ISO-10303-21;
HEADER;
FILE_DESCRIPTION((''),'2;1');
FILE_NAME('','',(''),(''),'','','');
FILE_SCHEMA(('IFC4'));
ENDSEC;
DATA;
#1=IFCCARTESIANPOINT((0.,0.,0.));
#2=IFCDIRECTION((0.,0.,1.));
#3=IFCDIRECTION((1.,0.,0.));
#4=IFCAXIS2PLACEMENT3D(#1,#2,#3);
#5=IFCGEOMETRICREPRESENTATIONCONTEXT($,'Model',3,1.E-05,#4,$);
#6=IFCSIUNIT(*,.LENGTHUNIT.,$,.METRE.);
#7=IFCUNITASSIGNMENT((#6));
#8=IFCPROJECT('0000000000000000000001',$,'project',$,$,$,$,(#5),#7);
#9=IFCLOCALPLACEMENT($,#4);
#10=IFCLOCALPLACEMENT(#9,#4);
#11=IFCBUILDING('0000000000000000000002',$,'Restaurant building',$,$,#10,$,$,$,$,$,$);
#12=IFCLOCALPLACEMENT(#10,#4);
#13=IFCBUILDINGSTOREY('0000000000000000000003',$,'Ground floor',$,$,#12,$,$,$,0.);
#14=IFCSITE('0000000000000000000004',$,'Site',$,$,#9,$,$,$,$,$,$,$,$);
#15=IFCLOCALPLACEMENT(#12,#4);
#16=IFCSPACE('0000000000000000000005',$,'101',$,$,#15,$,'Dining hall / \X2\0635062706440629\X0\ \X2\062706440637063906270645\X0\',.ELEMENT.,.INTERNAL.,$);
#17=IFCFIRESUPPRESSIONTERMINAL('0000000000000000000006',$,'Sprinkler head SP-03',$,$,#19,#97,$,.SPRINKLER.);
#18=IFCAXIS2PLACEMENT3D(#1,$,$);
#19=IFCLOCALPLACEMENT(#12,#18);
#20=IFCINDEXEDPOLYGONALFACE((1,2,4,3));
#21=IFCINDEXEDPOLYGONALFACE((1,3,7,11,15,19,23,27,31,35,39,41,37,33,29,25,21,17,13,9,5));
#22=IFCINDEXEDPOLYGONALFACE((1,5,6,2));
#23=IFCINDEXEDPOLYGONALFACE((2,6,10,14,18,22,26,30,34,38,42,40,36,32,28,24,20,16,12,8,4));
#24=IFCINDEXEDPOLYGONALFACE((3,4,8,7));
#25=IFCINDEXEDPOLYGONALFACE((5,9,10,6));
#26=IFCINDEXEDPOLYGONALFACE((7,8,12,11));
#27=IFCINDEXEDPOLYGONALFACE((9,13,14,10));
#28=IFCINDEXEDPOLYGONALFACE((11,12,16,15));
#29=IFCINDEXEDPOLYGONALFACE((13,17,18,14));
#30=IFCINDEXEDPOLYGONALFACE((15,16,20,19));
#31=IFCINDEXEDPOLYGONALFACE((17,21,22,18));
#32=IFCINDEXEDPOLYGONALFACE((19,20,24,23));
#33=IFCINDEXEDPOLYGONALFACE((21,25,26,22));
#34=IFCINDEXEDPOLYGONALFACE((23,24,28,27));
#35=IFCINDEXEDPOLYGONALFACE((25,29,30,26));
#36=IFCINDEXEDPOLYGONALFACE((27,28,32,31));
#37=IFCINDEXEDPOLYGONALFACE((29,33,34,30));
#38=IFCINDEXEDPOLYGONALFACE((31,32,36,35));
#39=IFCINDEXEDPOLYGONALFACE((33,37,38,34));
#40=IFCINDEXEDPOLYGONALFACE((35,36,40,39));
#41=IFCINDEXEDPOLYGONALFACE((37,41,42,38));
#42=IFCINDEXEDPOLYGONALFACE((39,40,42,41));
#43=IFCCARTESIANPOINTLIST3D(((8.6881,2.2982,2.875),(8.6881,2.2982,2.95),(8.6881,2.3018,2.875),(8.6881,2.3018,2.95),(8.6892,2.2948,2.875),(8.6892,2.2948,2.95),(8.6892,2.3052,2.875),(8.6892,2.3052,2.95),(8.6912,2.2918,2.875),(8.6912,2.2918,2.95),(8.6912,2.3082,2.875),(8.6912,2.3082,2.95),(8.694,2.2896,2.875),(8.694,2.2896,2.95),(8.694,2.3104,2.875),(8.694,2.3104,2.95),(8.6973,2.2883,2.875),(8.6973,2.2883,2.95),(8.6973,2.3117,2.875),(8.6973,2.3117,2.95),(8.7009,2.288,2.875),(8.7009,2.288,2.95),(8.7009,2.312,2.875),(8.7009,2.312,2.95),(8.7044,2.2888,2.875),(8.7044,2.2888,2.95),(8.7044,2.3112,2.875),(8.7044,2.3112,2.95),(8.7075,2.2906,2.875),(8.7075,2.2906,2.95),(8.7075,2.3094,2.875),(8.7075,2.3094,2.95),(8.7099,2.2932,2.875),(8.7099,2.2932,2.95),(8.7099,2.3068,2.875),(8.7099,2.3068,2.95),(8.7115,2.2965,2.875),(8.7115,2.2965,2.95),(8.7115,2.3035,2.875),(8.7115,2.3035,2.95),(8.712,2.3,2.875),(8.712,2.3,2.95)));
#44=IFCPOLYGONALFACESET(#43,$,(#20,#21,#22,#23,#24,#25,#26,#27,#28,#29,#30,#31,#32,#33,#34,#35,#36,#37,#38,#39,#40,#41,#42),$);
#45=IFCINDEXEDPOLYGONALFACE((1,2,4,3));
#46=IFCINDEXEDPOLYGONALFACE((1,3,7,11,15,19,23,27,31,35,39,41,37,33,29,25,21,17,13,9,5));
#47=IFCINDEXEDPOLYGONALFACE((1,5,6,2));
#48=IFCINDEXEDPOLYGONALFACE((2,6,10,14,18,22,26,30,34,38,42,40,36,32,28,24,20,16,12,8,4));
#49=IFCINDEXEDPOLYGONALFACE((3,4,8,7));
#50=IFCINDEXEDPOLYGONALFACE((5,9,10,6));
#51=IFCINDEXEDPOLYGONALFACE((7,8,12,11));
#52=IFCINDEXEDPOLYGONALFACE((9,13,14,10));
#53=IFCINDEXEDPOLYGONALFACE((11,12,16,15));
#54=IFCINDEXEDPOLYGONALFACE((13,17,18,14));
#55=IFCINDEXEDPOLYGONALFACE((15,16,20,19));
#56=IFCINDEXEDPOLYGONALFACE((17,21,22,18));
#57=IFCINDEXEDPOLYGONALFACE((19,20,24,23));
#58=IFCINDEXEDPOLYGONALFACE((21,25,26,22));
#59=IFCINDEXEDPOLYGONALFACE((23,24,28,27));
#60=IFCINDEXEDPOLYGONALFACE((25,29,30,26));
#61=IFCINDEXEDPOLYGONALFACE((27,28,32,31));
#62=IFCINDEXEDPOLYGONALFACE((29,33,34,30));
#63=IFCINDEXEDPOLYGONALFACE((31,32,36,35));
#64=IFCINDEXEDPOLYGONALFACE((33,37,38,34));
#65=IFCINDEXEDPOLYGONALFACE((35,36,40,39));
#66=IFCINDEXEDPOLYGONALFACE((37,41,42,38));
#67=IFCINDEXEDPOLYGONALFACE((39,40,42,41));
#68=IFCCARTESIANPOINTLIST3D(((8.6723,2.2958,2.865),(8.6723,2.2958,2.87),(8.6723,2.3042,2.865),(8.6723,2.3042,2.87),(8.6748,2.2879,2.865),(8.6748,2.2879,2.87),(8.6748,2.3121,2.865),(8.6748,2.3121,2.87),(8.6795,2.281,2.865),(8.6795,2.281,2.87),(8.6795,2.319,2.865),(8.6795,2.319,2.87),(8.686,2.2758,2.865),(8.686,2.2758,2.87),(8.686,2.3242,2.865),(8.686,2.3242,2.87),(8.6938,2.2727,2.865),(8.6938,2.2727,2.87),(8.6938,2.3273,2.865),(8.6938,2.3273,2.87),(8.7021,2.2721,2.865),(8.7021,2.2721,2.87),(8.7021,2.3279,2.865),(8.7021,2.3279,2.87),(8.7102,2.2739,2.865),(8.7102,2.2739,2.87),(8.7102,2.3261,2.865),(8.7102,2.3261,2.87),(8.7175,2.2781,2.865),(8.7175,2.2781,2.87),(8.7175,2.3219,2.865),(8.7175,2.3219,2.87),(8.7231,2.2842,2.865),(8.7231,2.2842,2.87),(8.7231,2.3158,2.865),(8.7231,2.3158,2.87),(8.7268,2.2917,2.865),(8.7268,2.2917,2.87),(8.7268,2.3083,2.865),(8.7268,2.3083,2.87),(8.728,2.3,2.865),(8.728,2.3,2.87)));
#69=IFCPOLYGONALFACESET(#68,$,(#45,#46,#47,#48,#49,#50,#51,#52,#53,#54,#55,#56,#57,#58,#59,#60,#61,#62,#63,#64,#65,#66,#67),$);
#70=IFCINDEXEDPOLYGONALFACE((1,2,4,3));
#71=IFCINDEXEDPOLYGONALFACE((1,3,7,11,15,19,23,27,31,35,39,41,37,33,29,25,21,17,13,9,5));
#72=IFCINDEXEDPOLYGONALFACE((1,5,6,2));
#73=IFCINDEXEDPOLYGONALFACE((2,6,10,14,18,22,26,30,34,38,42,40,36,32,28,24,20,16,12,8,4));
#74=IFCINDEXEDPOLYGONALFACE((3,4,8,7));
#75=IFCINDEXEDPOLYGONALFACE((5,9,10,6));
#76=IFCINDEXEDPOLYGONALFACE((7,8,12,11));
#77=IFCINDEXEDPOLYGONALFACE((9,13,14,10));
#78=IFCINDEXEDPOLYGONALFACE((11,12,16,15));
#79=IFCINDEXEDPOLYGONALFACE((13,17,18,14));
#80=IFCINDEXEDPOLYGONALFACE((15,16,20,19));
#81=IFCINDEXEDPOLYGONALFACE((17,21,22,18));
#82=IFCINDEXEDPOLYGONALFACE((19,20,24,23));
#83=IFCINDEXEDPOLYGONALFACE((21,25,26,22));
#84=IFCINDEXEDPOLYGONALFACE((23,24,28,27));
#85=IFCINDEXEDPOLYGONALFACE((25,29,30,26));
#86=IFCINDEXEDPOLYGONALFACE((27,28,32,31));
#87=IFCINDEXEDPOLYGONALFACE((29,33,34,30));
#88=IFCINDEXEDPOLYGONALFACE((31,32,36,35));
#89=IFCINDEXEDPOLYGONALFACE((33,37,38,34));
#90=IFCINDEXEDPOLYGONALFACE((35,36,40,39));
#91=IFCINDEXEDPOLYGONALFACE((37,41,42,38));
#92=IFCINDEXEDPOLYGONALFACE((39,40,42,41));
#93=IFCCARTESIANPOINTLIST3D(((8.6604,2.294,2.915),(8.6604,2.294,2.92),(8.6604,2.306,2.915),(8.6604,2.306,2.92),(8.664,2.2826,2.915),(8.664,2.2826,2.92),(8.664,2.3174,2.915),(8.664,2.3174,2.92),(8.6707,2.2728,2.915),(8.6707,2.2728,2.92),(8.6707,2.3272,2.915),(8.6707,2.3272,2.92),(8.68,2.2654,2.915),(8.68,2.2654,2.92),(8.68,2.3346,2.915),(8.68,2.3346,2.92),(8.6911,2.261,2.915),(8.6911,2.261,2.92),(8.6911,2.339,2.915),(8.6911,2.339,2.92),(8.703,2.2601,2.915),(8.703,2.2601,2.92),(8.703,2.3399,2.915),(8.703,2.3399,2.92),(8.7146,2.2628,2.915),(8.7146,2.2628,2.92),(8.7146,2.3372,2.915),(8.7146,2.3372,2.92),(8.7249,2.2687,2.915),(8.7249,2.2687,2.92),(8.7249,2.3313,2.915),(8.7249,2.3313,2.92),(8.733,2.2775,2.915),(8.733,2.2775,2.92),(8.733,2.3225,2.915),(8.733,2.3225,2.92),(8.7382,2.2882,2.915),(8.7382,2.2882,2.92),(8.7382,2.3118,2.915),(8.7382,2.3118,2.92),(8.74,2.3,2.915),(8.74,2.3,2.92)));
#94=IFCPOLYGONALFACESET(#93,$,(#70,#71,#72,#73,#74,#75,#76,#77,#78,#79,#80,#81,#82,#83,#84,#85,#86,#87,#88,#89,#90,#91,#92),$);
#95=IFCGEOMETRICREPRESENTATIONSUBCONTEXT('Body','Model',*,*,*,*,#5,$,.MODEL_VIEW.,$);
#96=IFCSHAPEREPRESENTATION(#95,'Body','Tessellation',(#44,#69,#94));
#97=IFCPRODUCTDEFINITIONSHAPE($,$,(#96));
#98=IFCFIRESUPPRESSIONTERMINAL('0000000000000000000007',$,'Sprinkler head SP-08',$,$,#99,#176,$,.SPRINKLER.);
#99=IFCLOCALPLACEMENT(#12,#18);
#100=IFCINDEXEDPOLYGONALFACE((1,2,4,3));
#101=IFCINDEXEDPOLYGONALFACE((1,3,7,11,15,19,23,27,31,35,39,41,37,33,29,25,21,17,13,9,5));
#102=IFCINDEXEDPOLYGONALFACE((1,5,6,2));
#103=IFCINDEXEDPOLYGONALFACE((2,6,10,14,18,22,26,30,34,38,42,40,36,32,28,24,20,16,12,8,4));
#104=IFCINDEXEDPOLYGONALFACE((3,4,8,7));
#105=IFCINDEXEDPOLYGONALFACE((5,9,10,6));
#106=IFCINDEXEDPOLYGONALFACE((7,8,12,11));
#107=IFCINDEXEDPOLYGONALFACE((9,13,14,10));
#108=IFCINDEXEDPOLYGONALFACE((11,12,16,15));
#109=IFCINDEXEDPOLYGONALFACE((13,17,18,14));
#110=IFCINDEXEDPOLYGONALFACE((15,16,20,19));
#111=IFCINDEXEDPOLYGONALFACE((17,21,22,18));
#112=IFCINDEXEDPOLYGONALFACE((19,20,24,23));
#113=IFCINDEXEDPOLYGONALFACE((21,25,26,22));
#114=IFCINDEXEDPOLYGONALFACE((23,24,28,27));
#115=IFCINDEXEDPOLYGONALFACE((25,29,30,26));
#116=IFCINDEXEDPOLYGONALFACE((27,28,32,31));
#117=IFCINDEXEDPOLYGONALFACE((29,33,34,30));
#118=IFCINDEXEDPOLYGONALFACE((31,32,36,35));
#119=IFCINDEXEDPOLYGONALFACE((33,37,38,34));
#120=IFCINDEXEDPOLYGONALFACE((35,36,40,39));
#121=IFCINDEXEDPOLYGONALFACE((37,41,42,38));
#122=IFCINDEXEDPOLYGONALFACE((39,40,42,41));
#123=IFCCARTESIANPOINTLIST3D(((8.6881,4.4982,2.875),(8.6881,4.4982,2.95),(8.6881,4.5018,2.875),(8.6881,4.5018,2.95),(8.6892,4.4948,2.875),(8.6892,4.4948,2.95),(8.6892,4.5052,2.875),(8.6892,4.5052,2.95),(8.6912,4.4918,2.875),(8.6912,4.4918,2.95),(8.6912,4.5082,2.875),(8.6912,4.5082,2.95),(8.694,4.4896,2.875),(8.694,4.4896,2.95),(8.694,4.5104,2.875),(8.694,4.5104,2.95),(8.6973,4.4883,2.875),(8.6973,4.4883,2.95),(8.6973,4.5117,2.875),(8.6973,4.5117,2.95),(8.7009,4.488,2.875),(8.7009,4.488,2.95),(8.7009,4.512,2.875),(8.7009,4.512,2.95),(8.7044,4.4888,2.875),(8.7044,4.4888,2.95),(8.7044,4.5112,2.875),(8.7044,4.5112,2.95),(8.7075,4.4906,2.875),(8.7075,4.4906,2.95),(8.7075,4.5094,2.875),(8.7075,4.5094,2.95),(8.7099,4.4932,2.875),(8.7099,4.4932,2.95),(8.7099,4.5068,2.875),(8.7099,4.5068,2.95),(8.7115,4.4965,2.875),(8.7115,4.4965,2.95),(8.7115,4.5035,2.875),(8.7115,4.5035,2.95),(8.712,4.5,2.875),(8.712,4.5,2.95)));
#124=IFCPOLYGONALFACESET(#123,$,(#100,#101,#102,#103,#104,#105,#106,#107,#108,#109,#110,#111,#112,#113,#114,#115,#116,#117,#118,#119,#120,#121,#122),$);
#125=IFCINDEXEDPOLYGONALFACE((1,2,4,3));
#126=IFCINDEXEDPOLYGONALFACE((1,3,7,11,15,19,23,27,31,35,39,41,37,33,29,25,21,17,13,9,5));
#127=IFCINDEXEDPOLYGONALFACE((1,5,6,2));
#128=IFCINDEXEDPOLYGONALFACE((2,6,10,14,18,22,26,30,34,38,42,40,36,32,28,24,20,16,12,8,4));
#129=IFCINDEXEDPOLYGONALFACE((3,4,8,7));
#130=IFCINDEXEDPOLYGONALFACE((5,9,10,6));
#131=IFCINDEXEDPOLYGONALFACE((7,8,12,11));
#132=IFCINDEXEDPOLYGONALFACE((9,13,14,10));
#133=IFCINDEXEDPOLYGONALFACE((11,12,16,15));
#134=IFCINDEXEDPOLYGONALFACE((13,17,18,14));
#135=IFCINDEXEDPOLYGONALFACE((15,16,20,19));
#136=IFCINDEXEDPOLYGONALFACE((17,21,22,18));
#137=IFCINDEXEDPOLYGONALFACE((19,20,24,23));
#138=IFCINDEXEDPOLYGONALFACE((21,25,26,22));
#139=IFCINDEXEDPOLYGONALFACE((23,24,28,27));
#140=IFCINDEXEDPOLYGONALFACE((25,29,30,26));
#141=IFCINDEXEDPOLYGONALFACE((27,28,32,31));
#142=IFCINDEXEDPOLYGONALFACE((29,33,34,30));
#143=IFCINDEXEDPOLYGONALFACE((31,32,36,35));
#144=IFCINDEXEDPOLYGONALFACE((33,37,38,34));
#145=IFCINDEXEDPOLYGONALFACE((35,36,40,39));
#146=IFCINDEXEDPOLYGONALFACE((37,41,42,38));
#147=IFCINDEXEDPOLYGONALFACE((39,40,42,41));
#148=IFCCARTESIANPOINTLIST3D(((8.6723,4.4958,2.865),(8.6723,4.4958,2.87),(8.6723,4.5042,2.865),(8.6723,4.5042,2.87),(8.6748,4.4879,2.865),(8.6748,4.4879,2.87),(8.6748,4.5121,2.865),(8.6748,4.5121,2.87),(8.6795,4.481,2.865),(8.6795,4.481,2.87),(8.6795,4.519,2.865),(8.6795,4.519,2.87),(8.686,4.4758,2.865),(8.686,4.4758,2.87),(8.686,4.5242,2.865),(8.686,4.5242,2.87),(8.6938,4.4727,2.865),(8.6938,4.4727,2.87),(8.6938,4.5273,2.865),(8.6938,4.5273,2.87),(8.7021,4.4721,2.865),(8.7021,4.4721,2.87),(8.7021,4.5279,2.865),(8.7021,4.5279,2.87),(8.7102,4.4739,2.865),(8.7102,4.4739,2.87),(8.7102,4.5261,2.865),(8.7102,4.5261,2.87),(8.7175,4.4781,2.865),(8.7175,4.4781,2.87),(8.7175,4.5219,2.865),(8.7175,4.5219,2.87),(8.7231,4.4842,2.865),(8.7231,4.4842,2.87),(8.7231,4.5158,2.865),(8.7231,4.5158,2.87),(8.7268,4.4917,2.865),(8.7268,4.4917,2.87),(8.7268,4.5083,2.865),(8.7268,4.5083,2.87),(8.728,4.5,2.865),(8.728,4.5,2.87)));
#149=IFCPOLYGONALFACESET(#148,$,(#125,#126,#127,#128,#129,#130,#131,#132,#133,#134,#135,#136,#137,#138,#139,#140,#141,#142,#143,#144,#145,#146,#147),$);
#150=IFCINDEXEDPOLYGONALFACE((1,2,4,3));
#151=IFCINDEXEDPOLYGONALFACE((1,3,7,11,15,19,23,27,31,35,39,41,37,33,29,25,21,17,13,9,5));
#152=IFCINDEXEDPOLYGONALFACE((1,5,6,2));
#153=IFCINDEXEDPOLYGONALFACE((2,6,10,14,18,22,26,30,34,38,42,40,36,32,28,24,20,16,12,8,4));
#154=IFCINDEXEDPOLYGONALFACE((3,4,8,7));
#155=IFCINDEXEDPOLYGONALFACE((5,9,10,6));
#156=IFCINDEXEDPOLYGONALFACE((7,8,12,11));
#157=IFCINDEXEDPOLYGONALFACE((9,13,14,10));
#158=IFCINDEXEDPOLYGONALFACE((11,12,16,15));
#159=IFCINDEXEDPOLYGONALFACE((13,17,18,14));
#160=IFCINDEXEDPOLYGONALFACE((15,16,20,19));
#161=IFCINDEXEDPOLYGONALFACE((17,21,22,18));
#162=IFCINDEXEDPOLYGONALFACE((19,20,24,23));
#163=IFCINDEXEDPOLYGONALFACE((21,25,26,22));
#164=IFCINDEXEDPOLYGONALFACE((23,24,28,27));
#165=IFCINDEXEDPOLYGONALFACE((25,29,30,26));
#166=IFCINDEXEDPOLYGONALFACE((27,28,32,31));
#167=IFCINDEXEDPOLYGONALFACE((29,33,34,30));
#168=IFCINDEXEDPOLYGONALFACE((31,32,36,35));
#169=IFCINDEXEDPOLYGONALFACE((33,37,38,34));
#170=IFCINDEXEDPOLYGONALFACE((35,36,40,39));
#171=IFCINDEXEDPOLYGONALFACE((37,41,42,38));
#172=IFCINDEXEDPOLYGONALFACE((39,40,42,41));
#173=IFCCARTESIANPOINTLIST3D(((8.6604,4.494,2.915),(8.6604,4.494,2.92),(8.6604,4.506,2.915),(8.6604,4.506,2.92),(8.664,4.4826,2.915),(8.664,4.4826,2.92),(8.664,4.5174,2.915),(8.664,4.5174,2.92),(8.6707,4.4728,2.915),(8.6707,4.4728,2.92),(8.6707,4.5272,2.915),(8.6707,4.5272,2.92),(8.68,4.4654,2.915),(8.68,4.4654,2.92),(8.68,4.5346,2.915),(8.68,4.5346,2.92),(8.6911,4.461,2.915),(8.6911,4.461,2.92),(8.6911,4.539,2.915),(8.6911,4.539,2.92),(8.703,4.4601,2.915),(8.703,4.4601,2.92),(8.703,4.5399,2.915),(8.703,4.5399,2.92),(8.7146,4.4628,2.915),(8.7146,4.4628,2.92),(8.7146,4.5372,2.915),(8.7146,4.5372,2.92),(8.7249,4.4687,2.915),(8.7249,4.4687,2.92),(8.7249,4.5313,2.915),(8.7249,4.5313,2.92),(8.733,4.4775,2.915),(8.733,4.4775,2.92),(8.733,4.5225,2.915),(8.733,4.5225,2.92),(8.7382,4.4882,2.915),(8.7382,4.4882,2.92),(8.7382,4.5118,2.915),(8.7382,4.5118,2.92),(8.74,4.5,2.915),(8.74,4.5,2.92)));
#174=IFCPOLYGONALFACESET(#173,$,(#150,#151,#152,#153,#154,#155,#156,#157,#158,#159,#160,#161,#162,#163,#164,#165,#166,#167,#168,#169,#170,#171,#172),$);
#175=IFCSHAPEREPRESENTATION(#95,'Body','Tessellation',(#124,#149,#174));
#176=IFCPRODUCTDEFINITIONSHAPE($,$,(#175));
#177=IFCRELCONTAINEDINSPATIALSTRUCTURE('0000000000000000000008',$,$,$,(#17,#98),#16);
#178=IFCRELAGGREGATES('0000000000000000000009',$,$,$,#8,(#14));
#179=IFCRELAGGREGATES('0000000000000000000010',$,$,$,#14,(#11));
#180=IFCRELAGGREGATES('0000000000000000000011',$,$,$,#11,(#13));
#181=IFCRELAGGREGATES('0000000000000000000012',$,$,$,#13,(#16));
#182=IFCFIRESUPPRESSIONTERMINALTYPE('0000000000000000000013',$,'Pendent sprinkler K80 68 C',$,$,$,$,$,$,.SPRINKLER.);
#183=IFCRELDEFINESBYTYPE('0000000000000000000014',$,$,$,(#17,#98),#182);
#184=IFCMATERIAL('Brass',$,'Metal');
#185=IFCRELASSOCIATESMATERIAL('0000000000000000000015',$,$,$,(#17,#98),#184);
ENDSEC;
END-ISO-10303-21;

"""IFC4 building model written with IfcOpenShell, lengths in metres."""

from ifc_helpers import new_model, si_unit, frame, origin, origin_with_axes, origin_2d, place, context, subcontext, project, spatial, circle, extrude, source, transform, mapped, material, type_object, type_shapes, element, save


model = new_model("IFC4")

# Units and contexts
model_context = context("Model", 3, precision=1e-05, world=origin_with_axes())
body_context = subcontext(model_context, "Body", "Model", "MODEL_VIEW")
ifc_project = project(units=[si_unit("LENGTHUNIT", "METRE")], contexts=[model_context])

# Site, building, storey
site_placement = place(None, origin_with_axes())
site = spatial("IfcSite", under=ifc_project, at=site_placement, Name="Site")
building_placement = place(site_placement, origin_with_axes())
building = spatial("IfcBuilding", under=site, at=building_placement, Name="Restaurant building")
storey_placement = place(building_placement, origin_with_axes())
storey = spatial("IfcBuildingStorey", under=building, at=storey_placement, Name="Ground floor", Elevation=0.0)

# Shared definitions
space_placement = place(storey_placement, origin_with_axes())
space = spatial("IfcSpace", under=storey, at=space_placement, Name="101", LongName="Dining hall / صالة الطعام", CompositionType="ELEMENT", PredefinedType="INTERNAL")

# Fire suppression terminals
ifc_material_1 = material(Name="Brass", Category="Metal")
fire_suppression_terminal_type = type_object("IfcFireSuppressionTerminalType", Name="Pendent sprinkler K80 68 C", PredefinedType="SPRINKLER")
shared_shape_1 = source(origin(), body_context, "Body", "SweptSolid", [
    extrude(circle(Radius=0.012, at=origin_2d()), frame((0.0, 0.0, -0.075)), (0.0, 0.0, 1.0), 0.075),
    extrude(circle(Radius=0.028, at=origin_2d()), frame((0.0, 0.0, -0.085)), (0.0, 0.0, 1.0), 0.005),
    extrude(circle(Radius=0.04, at=origin_2d()), frame((0.0, 0.0, -0.035)), (0.0, 0.0, 1.0), 0.005),
])
type_shapes(fire_suppression_terminal_type, [shared_shape_1])
for number, where, name in (
    (1, (8.7, 2.3, 2.95), "Sprinkler head SP-03"),
    (2, (8.7, 4.5, 2.95), "Sprinkler head SP-08"),
):
    element("IfcFireSuppressionTerminal", number, at=place(storey_placement, frame(where)), inside=space, type_object=fire_suppression_terminal_type, material=ifc_material_1, Name=name, PredefinedType="SPRINKLER", context=body_context, shape_type="MappedRepresentation", body=[
        mapped(shared_shape_1, transform((0.0, 0.0, 0.0))),
    ])

save(model, "model.ifc")
